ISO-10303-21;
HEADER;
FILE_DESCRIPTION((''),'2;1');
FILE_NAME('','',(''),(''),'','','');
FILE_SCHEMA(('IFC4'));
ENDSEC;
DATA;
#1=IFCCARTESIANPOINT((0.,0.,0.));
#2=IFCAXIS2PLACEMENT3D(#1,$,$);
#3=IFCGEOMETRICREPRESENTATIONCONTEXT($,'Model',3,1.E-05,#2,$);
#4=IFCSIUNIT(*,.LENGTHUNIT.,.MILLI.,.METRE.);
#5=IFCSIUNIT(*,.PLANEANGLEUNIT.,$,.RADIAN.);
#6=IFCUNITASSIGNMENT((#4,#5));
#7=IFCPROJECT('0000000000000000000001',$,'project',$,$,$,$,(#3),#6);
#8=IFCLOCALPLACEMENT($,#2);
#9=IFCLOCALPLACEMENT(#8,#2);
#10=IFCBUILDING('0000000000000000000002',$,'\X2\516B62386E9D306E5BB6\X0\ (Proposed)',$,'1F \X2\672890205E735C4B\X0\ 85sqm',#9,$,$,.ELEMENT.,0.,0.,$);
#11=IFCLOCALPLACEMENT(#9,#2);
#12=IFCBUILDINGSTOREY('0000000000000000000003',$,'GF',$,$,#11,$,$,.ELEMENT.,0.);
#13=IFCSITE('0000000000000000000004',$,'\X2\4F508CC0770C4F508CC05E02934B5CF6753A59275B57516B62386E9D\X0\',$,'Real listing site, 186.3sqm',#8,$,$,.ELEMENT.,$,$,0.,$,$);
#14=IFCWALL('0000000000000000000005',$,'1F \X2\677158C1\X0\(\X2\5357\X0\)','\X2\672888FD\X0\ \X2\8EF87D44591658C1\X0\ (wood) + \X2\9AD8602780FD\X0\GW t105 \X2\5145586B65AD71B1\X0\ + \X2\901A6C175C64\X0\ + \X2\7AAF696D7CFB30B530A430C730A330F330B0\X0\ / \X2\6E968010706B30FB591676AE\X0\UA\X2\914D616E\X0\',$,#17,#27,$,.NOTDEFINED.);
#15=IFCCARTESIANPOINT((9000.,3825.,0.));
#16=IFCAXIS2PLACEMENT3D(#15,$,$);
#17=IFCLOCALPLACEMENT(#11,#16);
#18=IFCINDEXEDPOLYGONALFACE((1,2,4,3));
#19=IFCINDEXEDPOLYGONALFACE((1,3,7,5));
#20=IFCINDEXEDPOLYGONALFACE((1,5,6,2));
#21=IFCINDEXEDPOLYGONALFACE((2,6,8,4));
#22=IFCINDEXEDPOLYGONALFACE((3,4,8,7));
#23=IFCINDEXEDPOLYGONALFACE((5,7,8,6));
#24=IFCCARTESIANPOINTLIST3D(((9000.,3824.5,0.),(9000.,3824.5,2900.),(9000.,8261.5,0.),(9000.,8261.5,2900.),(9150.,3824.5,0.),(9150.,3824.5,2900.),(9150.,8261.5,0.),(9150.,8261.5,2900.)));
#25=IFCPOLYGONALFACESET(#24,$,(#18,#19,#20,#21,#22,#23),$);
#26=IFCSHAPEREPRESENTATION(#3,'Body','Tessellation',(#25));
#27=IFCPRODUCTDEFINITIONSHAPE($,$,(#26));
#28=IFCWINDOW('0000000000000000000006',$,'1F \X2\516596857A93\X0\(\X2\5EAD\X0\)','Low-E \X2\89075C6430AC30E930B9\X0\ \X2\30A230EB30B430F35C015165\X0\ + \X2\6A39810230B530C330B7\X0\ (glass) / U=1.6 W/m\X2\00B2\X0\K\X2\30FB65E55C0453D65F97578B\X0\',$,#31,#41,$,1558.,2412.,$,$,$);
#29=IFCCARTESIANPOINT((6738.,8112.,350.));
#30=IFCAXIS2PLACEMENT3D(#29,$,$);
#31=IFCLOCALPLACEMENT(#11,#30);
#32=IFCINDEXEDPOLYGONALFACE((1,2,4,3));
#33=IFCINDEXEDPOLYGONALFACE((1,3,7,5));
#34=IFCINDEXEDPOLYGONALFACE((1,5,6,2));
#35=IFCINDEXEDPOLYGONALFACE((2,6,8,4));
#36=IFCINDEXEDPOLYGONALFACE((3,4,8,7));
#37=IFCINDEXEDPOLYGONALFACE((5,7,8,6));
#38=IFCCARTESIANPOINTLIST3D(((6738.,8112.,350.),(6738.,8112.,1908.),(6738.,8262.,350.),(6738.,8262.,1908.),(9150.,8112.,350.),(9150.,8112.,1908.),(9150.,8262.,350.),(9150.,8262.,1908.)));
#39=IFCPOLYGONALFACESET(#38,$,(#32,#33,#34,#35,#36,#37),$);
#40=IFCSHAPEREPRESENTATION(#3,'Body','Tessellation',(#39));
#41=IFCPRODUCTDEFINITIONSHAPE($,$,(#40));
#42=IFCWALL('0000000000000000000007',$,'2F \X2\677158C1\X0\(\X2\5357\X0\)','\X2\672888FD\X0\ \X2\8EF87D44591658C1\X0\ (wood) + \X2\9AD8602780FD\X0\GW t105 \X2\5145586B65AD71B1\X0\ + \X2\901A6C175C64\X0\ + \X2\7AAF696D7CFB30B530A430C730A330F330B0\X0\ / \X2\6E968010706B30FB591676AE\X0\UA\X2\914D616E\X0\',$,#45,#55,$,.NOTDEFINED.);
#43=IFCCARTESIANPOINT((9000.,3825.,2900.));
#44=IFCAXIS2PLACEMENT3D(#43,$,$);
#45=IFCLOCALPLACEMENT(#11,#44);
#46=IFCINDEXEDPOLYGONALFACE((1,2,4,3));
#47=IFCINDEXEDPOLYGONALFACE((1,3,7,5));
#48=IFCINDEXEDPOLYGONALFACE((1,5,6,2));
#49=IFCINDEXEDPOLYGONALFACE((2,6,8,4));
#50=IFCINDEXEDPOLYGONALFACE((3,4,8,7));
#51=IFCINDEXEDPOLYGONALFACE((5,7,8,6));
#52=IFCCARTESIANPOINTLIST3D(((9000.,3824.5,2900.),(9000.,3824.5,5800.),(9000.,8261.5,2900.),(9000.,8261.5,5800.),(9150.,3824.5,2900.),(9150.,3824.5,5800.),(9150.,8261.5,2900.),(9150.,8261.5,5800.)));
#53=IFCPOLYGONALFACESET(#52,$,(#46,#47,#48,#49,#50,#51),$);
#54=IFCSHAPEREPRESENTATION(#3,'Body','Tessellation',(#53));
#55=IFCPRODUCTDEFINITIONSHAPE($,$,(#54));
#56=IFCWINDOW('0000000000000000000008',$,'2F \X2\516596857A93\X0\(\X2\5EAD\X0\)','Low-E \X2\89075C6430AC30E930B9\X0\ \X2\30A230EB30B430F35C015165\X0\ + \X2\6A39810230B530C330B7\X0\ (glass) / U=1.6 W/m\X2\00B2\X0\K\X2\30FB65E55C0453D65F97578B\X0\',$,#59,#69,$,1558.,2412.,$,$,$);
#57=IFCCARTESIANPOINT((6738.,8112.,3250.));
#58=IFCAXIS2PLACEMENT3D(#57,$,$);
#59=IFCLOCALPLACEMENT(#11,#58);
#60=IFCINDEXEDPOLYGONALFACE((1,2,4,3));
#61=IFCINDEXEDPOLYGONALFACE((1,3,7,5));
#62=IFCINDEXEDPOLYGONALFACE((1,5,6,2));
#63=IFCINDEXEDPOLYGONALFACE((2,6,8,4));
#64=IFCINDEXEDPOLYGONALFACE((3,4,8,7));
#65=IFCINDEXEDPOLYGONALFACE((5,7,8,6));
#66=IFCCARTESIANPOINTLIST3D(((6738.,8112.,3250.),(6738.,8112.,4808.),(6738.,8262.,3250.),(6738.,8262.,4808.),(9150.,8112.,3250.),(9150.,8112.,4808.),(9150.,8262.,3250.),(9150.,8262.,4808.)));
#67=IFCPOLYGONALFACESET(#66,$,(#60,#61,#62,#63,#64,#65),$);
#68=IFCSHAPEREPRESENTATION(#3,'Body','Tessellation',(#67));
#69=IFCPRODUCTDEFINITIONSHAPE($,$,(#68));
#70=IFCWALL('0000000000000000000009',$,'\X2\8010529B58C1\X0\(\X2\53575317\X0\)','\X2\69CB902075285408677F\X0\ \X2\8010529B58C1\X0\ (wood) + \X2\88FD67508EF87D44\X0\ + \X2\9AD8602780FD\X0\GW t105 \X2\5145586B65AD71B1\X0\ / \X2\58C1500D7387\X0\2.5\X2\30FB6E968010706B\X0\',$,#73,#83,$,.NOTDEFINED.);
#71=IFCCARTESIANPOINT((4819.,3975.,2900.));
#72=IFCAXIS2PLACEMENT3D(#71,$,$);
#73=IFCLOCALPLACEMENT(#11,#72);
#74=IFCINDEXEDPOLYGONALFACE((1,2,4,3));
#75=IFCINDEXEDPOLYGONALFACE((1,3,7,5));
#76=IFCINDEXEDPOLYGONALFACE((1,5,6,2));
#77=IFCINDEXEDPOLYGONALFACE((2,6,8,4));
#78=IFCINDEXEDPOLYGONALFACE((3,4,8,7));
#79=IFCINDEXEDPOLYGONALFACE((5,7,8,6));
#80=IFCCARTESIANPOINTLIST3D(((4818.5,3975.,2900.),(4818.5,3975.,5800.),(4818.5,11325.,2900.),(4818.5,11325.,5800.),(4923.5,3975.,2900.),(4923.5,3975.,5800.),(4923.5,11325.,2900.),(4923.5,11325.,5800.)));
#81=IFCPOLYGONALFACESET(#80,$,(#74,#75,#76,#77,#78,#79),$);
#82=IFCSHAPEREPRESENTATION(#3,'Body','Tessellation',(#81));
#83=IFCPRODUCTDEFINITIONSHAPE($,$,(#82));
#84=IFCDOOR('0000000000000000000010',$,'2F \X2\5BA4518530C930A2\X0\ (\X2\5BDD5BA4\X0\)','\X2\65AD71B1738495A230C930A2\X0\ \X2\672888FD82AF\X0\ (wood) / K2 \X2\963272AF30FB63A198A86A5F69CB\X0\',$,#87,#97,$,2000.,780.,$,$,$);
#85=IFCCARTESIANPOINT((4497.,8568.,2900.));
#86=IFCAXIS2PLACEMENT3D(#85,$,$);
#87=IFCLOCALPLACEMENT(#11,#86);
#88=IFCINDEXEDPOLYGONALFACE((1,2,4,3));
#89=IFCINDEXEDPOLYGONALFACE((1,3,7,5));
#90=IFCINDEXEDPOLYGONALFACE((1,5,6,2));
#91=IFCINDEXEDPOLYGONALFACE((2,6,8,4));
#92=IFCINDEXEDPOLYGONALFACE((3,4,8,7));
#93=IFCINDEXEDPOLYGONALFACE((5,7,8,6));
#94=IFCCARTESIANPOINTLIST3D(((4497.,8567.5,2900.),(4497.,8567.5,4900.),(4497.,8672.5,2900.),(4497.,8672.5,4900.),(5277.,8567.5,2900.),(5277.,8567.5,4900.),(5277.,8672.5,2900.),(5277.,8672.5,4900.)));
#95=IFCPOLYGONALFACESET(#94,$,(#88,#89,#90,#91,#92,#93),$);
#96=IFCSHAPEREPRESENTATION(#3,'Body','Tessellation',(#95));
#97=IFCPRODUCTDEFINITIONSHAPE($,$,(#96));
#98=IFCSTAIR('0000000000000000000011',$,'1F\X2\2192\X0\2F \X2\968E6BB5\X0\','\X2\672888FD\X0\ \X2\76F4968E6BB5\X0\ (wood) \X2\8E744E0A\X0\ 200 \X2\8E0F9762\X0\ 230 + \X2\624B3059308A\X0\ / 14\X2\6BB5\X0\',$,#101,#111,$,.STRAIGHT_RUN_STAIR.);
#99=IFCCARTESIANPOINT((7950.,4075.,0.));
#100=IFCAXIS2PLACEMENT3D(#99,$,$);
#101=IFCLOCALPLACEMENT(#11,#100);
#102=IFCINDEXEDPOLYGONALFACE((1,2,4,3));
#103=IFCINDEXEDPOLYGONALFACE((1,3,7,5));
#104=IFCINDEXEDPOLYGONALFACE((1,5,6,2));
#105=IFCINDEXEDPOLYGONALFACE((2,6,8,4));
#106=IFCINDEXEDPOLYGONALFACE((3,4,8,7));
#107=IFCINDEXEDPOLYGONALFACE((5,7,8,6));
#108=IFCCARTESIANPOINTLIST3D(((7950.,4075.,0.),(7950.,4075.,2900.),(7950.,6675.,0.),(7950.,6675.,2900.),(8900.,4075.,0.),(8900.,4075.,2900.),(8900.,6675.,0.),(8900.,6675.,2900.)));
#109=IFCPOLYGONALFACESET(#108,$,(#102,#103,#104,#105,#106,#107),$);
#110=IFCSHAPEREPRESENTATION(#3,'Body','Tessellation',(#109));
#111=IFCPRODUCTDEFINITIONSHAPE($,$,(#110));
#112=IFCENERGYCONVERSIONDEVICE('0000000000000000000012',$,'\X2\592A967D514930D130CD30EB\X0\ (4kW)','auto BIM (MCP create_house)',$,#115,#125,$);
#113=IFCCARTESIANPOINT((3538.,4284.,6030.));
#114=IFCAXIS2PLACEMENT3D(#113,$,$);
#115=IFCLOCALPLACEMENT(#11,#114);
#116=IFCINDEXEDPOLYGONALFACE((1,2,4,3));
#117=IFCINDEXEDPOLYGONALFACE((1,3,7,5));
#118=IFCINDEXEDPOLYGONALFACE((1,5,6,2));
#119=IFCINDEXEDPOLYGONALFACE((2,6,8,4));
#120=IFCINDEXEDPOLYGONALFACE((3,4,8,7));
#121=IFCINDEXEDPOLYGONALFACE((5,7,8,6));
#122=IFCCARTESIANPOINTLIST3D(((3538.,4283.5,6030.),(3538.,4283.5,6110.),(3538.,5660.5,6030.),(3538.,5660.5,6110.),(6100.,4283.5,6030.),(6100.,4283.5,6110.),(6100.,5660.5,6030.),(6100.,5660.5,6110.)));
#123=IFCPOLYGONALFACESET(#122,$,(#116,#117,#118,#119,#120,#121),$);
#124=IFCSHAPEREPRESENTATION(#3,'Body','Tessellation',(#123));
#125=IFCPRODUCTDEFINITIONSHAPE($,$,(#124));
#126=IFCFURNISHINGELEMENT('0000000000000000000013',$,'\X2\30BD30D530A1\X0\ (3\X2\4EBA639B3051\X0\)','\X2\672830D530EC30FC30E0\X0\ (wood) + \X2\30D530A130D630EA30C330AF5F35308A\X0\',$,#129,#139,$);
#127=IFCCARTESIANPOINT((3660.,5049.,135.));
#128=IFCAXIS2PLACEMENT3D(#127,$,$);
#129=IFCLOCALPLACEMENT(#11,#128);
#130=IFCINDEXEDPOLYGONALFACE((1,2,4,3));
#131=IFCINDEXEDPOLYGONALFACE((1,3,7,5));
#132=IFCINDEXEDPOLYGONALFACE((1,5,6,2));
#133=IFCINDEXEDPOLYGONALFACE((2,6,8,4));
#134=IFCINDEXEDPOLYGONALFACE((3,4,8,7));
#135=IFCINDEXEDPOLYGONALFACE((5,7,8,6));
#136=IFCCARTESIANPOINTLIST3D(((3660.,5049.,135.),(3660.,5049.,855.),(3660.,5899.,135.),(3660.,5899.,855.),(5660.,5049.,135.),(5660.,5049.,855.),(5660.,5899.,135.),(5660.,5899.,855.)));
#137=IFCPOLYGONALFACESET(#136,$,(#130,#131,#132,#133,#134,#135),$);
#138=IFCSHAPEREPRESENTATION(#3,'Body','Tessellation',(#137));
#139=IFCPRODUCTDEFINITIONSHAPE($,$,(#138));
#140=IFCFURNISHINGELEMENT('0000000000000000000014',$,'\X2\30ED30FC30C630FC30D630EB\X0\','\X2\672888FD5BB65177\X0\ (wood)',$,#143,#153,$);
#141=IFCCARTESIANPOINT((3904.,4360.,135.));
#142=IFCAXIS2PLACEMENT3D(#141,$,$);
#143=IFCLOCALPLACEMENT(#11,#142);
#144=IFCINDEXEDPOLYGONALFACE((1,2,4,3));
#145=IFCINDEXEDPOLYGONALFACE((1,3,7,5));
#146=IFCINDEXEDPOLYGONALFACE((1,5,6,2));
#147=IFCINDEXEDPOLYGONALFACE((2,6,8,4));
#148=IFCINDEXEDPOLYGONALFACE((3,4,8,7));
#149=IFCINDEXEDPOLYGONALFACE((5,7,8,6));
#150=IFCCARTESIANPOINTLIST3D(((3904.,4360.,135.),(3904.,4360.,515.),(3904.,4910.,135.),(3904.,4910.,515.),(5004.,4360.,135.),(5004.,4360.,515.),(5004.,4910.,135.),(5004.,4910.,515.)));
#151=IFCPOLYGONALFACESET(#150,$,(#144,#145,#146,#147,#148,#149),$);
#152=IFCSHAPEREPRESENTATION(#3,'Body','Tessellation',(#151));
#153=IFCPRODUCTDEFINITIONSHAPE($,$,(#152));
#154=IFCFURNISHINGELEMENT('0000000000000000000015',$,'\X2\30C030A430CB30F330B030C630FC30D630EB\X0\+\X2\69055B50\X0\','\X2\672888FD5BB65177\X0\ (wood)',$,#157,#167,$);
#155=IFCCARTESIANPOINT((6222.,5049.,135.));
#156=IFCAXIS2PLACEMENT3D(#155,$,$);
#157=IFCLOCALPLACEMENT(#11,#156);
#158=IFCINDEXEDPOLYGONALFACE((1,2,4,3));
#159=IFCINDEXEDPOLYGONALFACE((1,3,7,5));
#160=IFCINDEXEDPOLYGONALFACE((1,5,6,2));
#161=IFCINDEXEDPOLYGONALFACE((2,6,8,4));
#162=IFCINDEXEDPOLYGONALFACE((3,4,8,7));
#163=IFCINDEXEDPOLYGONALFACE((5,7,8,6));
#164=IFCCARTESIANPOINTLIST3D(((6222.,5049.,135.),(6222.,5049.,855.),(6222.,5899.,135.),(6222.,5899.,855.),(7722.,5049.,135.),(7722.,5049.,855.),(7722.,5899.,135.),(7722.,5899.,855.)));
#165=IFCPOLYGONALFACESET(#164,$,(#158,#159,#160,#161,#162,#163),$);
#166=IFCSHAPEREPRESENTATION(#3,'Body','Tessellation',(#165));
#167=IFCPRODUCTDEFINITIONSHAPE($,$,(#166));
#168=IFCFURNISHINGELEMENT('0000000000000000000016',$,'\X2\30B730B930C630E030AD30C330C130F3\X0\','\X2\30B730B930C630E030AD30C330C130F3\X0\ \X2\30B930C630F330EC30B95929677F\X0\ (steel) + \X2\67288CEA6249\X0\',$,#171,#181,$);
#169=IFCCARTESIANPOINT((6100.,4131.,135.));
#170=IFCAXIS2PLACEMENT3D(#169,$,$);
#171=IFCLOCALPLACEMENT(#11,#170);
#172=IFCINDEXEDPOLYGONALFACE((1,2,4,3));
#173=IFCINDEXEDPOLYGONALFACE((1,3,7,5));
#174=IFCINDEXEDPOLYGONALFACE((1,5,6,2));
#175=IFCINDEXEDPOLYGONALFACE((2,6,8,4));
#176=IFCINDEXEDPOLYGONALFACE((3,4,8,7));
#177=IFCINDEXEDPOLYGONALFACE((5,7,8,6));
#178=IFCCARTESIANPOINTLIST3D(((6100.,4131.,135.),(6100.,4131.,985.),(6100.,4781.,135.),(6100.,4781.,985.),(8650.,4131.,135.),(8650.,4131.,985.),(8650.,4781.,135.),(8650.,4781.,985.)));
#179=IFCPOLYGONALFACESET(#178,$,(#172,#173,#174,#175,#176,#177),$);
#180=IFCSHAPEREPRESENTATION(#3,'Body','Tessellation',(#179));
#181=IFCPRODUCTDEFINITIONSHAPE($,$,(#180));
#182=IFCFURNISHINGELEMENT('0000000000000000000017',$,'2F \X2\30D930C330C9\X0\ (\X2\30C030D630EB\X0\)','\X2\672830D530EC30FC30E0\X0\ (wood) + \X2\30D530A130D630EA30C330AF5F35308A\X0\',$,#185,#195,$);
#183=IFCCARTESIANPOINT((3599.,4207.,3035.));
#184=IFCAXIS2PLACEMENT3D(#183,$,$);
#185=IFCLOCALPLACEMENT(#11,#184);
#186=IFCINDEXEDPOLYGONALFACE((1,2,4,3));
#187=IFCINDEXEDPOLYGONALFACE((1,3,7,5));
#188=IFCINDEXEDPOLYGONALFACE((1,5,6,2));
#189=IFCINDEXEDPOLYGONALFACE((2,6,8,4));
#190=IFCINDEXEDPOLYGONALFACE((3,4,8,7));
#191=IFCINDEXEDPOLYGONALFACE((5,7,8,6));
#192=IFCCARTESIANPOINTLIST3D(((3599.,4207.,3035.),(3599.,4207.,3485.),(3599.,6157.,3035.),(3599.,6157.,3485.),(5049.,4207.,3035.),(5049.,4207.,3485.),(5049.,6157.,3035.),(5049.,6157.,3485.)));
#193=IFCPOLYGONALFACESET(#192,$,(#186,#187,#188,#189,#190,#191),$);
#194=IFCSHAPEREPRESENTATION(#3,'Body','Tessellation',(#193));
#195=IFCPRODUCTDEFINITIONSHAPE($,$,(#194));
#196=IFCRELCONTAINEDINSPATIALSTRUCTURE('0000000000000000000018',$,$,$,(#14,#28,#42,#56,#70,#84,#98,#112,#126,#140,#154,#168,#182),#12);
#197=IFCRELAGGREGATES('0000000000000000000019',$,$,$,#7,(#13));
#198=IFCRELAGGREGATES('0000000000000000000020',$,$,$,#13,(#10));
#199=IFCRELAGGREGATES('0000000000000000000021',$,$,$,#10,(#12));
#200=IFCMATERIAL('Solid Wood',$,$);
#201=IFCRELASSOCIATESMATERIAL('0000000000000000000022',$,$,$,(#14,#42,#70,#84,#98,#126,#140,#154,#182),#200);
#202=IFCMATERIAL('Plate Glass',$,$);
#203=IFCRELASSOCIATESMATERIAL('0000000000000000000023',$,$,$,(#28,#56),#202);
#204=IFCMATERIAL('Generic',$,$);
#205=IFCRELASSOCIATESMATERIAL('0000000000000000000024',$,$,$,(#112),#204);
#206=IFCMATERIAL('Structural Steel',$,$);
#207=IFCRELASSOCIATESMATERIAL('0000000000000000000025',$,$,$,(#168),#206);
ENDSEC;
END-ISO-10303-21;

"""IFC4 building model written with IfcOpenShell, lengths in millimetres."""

from ifc_helpers import new_model, si_unit, frame, frame_2d, origin, place, context, project, spatial, rectangle, extrude, material, element, fill, save


model = new_model("IFC4")

# Units and contexts
model_context = context("Model", 3, precision=1e-05, world=origin())
ifc_project = project(units=[si_unit("LENGTHUNIT", "METRE", prefix="MILLI"), si_unit("PLANEANGLEUNIT", "RADIAN")], contexts=[model_context])

# Site, building, storey
site_placement = place(None, origin())
site = spatial("IfcSite", under=ifc_project, at=site_placement, Name="佐賀県佐賀市鍋島町大字八戸溝", ObjectType="Real listing site, 186.3sqm", CompositionType="ELEMENT", RefElevation=0.0)
building_placement = place(site_placement, origin())
building = spatial("IfcBuilding", under=site, at=building_placement, Name="八戸溝の家 (Proposed)", ObjectType="1F 木造平屋 85sqm", CompositionType="ELEMENT", ElevationOfRefHeight=0.0, ElevationOfTerrain=0.0)
storey_placement = place(building_placement, origin())
storey = spatial("IfcBuildingStorey", under=building, at=storey_placement, Name="GF", CompositionType="ELEMENT", Elevation=0.0)

# Wall, opening, window
ifc_material_1 = material(Name="Solid Wood")
wall_1_placement = place(storey_placement, frame((9000.0, 3825.0, 0.0)))
wall_1 = element("IfcWall", 1, at=wall_1_placement, inside=storey, material=ifc_material_1, Name="1F 東壁(南)", Description="木製 軸組外壁 (wood) + 高性能GW t105 充填断熱 + 通気層 + 窯業系サイディング / 準耐火・外皮UA配慮", PredefinedType="NOTDEFINED", context=model_context, shape_type="SweptSolid", body=[
    extrude(rectangle(XDim=150.0, YDim=4437.0, at=frame_2d((75.0, 2218.0))), frame((9000.0, 3825.0, 0.0)), (0.0, 0.0, 1.0), 2900.0),
])
opening_1_placement = place(storey_placement, frame((6738.0, 8112.0, 350.0)))
opening_1 = element("IfcOpeningElement", 2, at=opening_1_placement, cuts=wall_1, PredefinedType="NOTDEFINED", context=model_context, shape_type="SweptSolid", body=[
    extrude(rectangle(XDim=2412.0, YDim=150.0, at=frame_2d((1206.0, 75.0))), frame((6738.0, 8112.0, 350.0)), (0.0, 0.0, 1.0), 1558.0),
])
ifc_material_2 = material(Name="Plate Glass")
window_1_placement = place(storey_placement, frame((6738.0, 8112.0, 350.0)))
window_1 = element("IfcWindow", 3, at=window_1_placement, inside=storey, material=ifc_material_2, Name="1F 入隅窓(庭)", Description="Low-E 複層ガラス アルゴン封入 + 樹脂サッシ (glass) / U=1.6 W/m²K・日射取得型", OverallHeight=1558.0, OverallWidth=2412.0, context=model_context, shape_type="SweptSolid", body=[
    extrude(rectangle(XDim=2412.0, YDim=150.0, at=frame_2d((1206.0, 75.0))), frame((6738.0, 8112.0, 350.0)), (0.0, 0.0, 1.0), 1558.0),
])
fill(opening_1, window_1)

# Wall, opening, window
wall_2_placement = place(storey_placement, frame((9000.0, 3825.0, 2900.0)))
wall_2 = element("IfcWall", 4, at=wall_2_placement, inside=storey, material=ifc_material_1, Name="2F 東壁(南)", Description="木製 軸組外壁 (wood) + 高性能GW t105 充填断熱 + 通気層 + 窯業系サイディング / 準耐火・外皮UA配慮", PredefinedType="NOTDEFINED", context=model_context, shape_type="SweptSolid", body=[
    extrude(rectangle(XDim=150.0, YDim=4437.0, at=frame_2d((75.0, 2218.0))), frame((9000.0, 3825.0, 2900.0)), (0.0, 0.0, 1.0), 2900.0),
])
opening_2_placement = place(storey_placement, frame((6738.0, 8112.0, 3250.0)))
opening_2 = element("IfcOpeningElement", 5, at=opening_2_placement, cuts=wall_2, PredefinedType="NOTDEFINED", context=model_context, shape_type="SweptSolid", body=[
    extrude(rectangle(XDim=2412.0, YDim=150.0, at=frame_2d((1206.0, 75.0))), frame((6738.0, 8112.0, 3250.0)), (0.0, 0.0, 1.0), 1558.0),
])
window_2_placement = place(storey_placement, frame((6738.0, 8112.0, 3250.0)))
window_2 = element("IfcWindow", 6, at=window_2_placement, inside=storey, material=ifc_material_2, Name="2F 入隅窓(庭)", Description="Low-E 複層ガラス アルゴン封入 + 樹脂サッシ (glass) / U=1.6 W/m²K・日射取得型", OverallHeight=1558.0, OverallWidth=2412.0, context=model_context, shape_type="SweptSolid", body=[
    extrude(rectangle(XDim=2412.0, YDim=150.0, at=frame_2d((1206.0, 75.0))), frame((6738.0, 8112.0, 3250.0)), (0.0, 0.0, 1.0), 1558.0),
])
fill(opening_2, window_2)

# Wall, opening, door
wall_3_placement = place(storey_placement, frame((4819.0, 3975.0, 2900.0)))
wall_3 = element("IfcWall", 7, at=wall_3_placement, inside=storey, material=ifc_material_1, Name="耐力壁(南北)", Description="構造用合板 耐力壁 (wood) + 製材軸組 + 高性能GW t105 充填断熱 / 壁倍率2.5・準耐火", PredefinedType="NOTDEFINED", context=model_context, shape_type="SweptSolid", body=[
    extrude(rectangle(XDim=105.0, YDim=7350.0, at=frame_2d((52.0, 3675.0))), frame((4819.0, 3975.0, 2900.0)), (0.0, 0.0, 1.0), 2900.0),
])
opening_3_placement = place(storey_placement, frame((4497.0, 8568.0, 2900.0)))
opening_3 = element("IfcOpeningElement", 8, at=opening_3_placement, cuts=wall_3, PredefinedType="NOTDEFINED", context=model_context, shape_type="SweptSolid", body=[
    extrude(rectangle(XDim=780.0, YDim=105.0, at=frame_2d((390.0, 52.0))), frame((4497.0, 8568.0, 2900.0)), (0.0, 0.0, 1.0), 2000.0),
])
door_1_placement = place(storey_placement, frame((4497.0, 8568.0, 2900.0)))
door_1 = element("IfcDoor", 9, at=door_1_placement, inside=storey, material=ifc_material_1, Name="2F 室内ドア (寝室)", Description="断熱玄関ドア 木製芯 (wood) / K2 防犯・採風機構", OverallHeight=2000.0, OverallWidth=780.0, context=model_context, shape_type="SweptSolid", body=[
    extrude(rectangle(XDim=780.0, YDim=105.0, at=frame_2d((390.0, 52.0))), frame((4497.0, 8568.0, 2900.0)), (0.0, 0.0, 1.0), 2000.0),
])
fill(opening_3, door_1)

# Stair
stair_placement = place(storey_placement, frame((7950.0, 4075.0, 0.0)))
element("IfcStair", 10, at=stair_placement, inside=storey, material=ifc_material_1, Name="1F→2F 階段", Description="木製 直階段 (wood) 蹴上 200 踏面 230 + 手すり / 14段", PredefinedType="STRAIGHT_RUN_STAIR", context=model_context, shape_type="SweptSolid", body=[
    extrude(rectangle(XDim=950.0, YDim=2600.0, at=frame_2d((475.0, 1300.0))), frame((7950.0, 4075.0, 0.0)), (0.0, 0.0, 1.0), 2900.0),
])

# Energy conversion device
ifc_material_3 = material(Name="Generic")
energy_conversion_device_placement = place(storey_placement, frame((3538.0, 4284.0, 6030.0)))
element("IfcEnergyConversionDevice", 11, at=energy_conversion_device_placement, inside=storey, material=ifc_material_3, Name="太陽光パネル (4kW)", Description="auto BIM (MCP create_house)", context=model_context, shape_type="SweptSolid", body=[
    extrude(rectangle(XDim=2562.0, YDim=1377.0, at=frame_2d((1281.0, 688.0))), frame((3538.0, 4284.0, 6030.0)), (0.0, 0.0, 1.0), 80.0),
])

# Furnishing elements
furnishing_1_placement = place(storey_placement, frame((3660.0, 5049.0, 135.0)))
element("IfcFurnishingElement", 12, at=furnishing_1_placement, inside=storey, material=ifc_material_1, Name="ソファ (3人掛け)", Description="木フレーム (wood) + ファブリック張り", context=model_context, shape_type="SweptSolid", body=[
    extrude(rectangle(XDim=2000.0, YDim=850.0, at=frame_2d((1000.0, 425.0))), frame((3660.0, 5049.0, 135.0)), (0.0, 0.0, 1.0), 720.0),
])
furnishing_2_placement = place(storey_placement, frame((3904.0, 4360.0, 135.0)))
element("IfcFurnishingElement", 13, at=furnishing_2_placement, inside=storey, material=ifc_material_1, Name="ローテーブル", Description="木製家具 (wood)", context=model_context, shape_type="SweptSolid", body=[
    extrude(rectangle(XDim=1100.0, YDim=550.0, at=frame_2d((550.0, 275.0))), frame((3904.0, 4360.0, 135.0)), (0.0, 0.0, 1.0), 380.0),
])
furnishing_3_placement = place(storey_placement, frame((6222.0, 5049.0, 135.0)))
element("IfcFurnishingElement", 14, at=furnishing_3_placement, inside=storey, material=ifc_material_1, Name="ダイニングテーブル+椅子", Description="木製家具 (wood)", context=model_context, shape_type="SweptSolid", body=[
    extrude(rectangle(XDim=1500.0, YDim=850.0, at=frame_2d((750.0, 425.0))), frame((6222.0, 5049.0, 135.0)), (0.0, 0.0, 1.0), 720.0),
])
ifc_material_4 = material(Name="Structural Steel")
furnishing_4_placement = place(storey_placement, frame((6100.0, 4131.0, 135.0)))
element("IfcFurnishingElement", 15, at=furnishing_4_placement, inside=storey, material=ifc_material_4, Name="システムキッチン", Description="システムキッチン ステンレス天板 (steel) + 木質扉", context=model_context, shape_type="SweptSolid", body=[
    extrude(rectangle(XDim=2550.0, YDim=650.0, at=frame_2d((1275.0, 325.0))), frame((6100.0, 4131.0, 135.0)), (0.0, 0.0, 1.0), 850.0),
])
furnishing_5_placement = place(storey_placement, frame((3599.0, 4207.0, 3035.0)))
element("IfcFurnishingElement", 16, at=furnishing_5_placement, inside=storey, material=ifc_material_1, Name="2F ベッド (ダブル)", Description="木フレーム (wood) + ファブリック張り", context=model_context, shape_type="SweptSolid", body=[
    extrude(rectangle(XDim=1450.0, YDim=1950.0, at=frame_2d((725.0, 975.0))), frame((3599.0, 4207.0, 3035.0)), (0.0, 0.0, 1.0), 450.0),
])

save(model, "model.ifc")
